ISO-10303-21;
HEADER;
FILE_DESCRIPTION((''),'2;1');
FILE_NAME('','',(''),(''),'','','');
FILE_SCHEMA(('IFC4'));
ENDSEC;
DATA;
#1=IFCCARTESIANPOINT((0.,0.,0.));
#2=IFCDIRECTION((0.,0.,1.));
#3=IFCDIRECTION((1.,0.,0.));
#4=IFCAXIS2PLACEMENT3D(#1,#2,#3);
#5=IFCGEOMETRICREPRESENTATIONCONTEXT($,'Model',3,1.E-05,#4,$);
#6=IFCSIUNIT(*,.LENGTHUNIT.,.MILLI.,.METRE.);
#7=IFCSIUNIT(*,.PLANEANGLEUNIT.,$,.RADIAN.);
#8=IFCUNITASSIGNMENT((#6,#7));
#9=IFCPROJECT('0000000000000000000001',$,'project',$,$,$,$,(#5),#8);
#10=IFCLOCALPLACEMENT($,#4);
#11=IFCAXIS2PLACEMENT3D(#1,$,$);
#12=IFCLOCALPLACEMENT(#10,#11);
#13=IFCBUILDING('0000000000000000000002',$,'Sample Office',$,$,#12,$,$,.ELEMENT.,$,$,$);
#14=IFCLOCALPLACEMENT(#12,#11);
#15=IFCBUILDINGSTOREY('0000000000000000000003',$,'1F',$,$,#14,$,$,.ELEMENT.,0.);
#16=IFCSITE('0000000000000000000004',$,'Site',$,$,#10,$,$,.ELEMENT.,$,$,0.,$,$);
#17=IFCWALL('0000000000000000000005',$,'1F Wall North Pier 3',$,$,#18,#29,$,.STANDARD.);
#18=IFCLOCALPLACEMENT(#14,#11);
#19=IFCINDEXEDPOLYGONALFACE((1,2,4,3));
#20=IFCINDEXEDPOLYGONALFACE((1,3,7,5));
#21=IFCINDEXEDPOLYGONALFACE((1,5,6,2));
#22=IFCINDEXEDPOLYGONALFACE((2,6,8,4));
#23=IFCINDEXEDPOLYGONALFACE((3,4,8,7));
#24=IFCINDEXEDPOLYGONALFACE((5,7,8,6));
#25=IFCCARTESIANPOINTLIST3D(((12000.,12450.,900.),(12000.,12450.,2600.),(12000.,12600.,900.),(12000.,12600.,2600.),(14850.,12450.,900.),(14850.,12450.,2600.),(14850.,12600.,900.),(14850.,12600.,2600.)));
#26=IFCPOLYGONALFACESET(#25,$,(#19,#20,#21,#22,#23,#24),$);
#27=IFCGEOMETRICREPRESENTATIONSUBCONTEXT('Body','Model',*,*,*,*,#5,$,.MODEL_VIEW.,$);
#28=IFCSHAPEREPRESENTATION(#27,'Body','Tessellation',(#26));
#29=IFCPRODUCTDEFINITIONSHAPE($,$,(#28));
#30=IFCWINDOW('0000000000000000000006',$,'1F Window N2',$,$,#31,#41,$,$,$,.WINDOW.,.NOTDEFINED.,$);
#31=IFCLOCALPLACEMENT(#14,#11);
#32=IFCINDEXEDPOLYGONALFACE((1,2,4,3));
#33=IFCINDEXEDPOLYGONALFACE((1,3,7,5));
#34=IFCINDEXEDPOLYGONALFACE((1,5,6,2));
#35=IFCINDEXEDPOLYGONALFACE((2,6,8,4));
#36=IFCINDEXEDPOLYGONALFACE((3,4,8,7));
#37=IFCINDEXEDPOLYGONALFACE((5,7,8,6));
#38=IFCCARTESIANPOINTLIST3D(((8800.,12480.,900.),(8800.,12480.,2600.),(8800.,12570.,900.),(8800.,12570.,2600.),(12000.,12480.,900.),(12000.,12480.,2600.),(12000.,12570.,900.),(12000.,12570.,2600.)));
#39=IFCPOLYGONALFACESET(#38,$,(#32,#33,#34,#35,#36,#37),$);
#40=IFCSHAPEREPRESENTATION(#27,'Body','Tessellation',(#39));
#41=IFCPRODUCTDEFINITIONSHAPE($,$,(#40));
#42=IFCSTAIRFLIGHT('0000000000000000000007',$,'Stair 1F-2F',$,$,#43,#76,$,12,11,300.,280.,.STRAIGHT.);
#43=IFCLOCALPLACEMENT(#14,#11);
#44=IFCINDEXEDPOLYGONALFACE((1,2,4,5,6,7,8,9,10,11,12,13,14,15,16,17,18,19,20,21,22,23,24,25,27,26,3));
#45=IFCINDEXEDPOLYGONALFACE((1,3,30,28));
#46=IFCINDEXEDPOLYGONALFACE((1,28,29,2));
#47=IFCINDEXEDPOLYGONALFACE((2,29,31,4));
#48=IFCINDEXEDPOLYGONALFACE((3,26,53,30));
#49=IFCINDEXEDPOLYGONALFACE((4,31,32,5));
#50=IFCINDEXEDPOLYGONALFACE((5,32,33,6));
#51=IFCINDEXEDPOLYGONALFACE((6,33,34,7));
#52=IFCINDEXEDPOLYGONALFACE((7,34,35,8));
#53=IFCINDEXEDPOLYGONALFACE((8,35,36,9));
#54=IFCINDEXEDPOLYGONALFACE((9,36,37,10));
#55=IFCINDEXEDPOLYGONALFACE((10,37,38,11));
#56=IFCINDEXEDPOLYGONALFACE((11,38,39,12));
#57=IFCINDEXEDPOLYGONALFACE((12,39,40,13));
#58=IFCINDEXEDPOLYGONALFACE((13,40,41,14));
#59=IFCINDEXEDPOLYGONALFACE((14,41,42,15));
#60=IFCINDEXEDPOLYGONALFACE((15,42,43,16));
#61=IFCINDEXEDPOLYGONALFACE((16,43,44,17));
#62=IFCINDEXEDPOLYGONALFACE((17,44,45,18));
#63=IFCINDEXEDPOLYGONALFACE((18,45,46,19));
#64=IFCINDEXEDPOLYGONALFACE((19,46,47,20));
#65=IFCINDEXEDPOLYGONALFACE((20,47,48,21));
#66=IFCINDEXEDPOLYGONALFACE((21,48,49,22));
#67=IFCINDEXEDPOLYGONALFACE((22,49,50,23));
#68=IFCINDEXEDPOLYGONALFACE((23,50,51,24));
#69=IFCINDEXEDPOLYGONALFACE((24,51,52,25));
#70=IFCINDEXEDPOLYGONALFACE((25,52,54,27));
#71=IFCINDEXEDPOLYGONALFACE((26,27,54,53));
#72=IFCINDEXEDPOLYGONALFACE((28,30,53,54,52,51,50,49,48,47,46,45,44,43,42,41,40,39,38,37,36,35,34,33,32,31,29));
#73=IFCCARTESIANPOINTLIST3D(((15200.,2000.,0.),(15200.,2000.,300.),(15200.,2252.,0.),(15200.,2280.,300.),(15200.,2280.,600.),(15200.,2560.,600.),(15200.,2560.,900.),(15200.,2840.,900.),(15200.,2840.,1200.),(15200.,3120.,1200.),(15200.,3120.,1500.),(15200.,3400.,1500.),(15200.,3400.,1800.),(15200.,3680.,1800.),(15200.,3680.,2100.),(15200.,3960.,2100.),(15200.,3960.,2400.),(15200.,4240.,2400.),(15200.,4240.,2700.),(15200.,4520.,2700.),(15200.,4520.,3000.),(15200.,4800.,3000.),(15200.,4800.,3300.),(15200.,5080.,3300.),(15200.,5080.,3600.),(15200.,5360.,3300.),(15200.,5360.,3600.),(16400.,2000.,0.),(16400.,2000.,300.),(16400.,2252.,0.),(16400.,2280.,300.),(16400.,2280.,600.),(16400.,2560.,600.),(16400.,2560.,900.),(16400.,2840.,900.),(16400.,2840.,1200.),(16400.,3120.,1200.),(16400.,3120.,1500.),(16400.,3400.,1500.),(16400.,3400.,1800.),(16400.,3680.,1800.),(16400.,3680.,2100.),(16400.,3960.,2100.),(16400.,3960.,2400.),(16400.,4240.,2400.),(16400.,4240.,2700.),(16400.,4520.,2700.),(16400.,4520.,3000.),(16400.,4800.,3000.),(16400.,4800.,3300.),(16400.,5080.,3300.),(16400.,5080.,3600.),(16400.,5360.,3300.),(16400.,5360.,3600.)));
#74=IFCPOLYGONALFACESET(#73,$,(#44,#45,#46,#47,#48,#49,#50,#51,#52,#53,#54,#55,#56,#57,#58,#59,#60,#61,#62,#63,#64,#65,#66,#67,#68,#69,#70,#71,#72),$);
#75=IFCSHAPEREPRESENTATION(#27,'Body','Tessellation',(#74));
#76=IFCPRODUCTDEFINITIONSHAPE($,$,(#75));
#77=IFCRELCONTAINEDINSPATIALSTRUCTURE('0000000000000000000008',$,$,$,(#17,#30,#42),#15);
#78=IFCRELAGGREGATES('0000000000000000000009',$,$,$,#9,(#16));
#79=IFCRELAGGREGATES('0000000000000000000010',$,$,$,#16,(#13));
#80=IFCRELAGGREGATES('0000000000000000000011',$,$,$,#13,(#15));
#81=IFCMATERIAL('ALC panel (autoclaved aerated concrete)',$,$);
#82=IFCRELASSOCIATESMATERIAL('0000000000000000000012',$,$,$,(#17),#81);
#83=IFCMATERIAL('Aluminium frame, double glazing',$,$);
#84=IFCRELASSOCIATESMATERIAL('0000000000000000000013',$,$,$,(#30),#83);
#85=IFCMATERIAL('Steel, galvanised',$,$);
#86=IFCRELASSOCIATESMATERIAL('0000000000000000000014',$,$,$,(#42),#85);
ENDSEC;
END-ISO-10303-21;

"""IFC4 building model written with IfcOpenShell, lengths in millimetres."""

from ifc_helpers import new_model, si_unit, frame, origin, origin_with_axes, origin_2d, place, context, subcontext, project, spatial, polyline, rectangle, outline, extrude, material, element, save


model = new_model("IFC4")

# Units and contexts
model_context = context("Model", 3, precision=1e-05, world=origin_with_axes())
body_context = subcontext(model_context, "Body", "Model", "MODEL_VIEW")
ifc_project = project(units=[si_unit("LENGTHUNIT", "METRE", prefix="MILLI"), si_unit("PLANEANGLEUNIT", "RADIAN")], contexts=[model_context])

# Site, building, storey
site_placement = place(None, origin_with_axes())
site = spatial("IfcSite", under=ifc_project, at=site_placement, Name="Site", CompositionType="ELEMENT", RefElevation=0.0)
building_placement = place(site_placement, origin())
building = spatial("IfcBuilding", under=site, at=building_placement, Name="Sample Office", CompositionType="ELEMENT")
storey_placement = place(building_placement, origin())
storey = spatial("IfcBuildingStorey", under=building, at=storey_placement, Name="1F", CompositionType="ELEMENT", Elevation=0.0)

# Wall
ifc_material_1 = material(Name="ALC panel (autoclaved aerated concrete)")
wall_1_placement = place(storey_placement, frame((13425.0, 12525.0, 900.0)))
element("IfcWall", 1, at=wall_1_placement, inside=storey, material=ifc_material_1, Name="1F Wall North Pier 3", PredefinedType="STANDARD", context=body_context, shape_type="SweptSolid", body=[
    extrude(rectangle(XDim=2850.0, YDim=150.0, at=origin_2d()), origin(), (0.0, 0.0, 1.0), 1700.0),
])

# Window
ifc_material_2 = material(Name="Aluminium frame, double glazing")
window_placement = place(storey_placement, frame((10400.0, 12525.0, 900.0)))
element("IfcWindow", 2, at=window_placement, inside=storey, material=ifc_material_2, Name="1F Window N2", PartitioningType="NOTDEFINED", PredefinedType="WINDOW", context=body_context, shape_type="SweptSolid", body=[
    extrude(rectangle(XDim=3200.0, YDim=90.0, at=origin_2d()), origin(), (0.0, 0.0, 1.0), 1700.0),
])

# Stair flight
ifc_material_3 = material(Name="Steel, galvanised")
stair_flight_placement = place(storey_placement, frame((15200.0, 2000.0, 0.0)))
element("IfcStairFlight", 3, at=stair_flight_placement, inside=storey, material=ifc_material_3, Name="Stair 1F-2F", NumberOfRisers=12, NumberOfTreads=11, PredefinedType="STRAIGHT", RiserHeight=300.0, TreadLength=280.0, context=body_context, shape_type="SweptSolid", body=[
    extrude(outline(polyline([(0.0, 0.0), (0.0, 300.0), (280.0, 300.0), (280.0, 600.0), (560.0, 600.0), (560.0, 900.0), (840.0, 900.0), (840.0, 1200.0), (1120.0, 1200.0), (1120.0, 1500.0), (1400.0, 1500.0), (1400.0, 1800.0), (1680.0, 1800.0), (1680.0, 2100.0), (1960.0, 2100.0), (1960.0, 2400.0), (2240.0, 2400.0), (2240.0, 2700.0), (2520.0, 2700.0), (2520.0, 3000.0), (2800.0, 3000.0), (2800.0, 3300.0), (3080.0, 3300.0), (3080.0, 3600.0), (3360.0, 3600.0), (3360.0, 3300.0), (252.0, 0.0), (0.0, 0.0)])), frame((0.0, 0.0, 0.0), z_axis=(1.0, 0.0, 0.0), x_axis=(0.0, 1.0, 0.0)), (0.0, 0.0, 1.0), 1200.0),
])

save(model, "model.ifc")
